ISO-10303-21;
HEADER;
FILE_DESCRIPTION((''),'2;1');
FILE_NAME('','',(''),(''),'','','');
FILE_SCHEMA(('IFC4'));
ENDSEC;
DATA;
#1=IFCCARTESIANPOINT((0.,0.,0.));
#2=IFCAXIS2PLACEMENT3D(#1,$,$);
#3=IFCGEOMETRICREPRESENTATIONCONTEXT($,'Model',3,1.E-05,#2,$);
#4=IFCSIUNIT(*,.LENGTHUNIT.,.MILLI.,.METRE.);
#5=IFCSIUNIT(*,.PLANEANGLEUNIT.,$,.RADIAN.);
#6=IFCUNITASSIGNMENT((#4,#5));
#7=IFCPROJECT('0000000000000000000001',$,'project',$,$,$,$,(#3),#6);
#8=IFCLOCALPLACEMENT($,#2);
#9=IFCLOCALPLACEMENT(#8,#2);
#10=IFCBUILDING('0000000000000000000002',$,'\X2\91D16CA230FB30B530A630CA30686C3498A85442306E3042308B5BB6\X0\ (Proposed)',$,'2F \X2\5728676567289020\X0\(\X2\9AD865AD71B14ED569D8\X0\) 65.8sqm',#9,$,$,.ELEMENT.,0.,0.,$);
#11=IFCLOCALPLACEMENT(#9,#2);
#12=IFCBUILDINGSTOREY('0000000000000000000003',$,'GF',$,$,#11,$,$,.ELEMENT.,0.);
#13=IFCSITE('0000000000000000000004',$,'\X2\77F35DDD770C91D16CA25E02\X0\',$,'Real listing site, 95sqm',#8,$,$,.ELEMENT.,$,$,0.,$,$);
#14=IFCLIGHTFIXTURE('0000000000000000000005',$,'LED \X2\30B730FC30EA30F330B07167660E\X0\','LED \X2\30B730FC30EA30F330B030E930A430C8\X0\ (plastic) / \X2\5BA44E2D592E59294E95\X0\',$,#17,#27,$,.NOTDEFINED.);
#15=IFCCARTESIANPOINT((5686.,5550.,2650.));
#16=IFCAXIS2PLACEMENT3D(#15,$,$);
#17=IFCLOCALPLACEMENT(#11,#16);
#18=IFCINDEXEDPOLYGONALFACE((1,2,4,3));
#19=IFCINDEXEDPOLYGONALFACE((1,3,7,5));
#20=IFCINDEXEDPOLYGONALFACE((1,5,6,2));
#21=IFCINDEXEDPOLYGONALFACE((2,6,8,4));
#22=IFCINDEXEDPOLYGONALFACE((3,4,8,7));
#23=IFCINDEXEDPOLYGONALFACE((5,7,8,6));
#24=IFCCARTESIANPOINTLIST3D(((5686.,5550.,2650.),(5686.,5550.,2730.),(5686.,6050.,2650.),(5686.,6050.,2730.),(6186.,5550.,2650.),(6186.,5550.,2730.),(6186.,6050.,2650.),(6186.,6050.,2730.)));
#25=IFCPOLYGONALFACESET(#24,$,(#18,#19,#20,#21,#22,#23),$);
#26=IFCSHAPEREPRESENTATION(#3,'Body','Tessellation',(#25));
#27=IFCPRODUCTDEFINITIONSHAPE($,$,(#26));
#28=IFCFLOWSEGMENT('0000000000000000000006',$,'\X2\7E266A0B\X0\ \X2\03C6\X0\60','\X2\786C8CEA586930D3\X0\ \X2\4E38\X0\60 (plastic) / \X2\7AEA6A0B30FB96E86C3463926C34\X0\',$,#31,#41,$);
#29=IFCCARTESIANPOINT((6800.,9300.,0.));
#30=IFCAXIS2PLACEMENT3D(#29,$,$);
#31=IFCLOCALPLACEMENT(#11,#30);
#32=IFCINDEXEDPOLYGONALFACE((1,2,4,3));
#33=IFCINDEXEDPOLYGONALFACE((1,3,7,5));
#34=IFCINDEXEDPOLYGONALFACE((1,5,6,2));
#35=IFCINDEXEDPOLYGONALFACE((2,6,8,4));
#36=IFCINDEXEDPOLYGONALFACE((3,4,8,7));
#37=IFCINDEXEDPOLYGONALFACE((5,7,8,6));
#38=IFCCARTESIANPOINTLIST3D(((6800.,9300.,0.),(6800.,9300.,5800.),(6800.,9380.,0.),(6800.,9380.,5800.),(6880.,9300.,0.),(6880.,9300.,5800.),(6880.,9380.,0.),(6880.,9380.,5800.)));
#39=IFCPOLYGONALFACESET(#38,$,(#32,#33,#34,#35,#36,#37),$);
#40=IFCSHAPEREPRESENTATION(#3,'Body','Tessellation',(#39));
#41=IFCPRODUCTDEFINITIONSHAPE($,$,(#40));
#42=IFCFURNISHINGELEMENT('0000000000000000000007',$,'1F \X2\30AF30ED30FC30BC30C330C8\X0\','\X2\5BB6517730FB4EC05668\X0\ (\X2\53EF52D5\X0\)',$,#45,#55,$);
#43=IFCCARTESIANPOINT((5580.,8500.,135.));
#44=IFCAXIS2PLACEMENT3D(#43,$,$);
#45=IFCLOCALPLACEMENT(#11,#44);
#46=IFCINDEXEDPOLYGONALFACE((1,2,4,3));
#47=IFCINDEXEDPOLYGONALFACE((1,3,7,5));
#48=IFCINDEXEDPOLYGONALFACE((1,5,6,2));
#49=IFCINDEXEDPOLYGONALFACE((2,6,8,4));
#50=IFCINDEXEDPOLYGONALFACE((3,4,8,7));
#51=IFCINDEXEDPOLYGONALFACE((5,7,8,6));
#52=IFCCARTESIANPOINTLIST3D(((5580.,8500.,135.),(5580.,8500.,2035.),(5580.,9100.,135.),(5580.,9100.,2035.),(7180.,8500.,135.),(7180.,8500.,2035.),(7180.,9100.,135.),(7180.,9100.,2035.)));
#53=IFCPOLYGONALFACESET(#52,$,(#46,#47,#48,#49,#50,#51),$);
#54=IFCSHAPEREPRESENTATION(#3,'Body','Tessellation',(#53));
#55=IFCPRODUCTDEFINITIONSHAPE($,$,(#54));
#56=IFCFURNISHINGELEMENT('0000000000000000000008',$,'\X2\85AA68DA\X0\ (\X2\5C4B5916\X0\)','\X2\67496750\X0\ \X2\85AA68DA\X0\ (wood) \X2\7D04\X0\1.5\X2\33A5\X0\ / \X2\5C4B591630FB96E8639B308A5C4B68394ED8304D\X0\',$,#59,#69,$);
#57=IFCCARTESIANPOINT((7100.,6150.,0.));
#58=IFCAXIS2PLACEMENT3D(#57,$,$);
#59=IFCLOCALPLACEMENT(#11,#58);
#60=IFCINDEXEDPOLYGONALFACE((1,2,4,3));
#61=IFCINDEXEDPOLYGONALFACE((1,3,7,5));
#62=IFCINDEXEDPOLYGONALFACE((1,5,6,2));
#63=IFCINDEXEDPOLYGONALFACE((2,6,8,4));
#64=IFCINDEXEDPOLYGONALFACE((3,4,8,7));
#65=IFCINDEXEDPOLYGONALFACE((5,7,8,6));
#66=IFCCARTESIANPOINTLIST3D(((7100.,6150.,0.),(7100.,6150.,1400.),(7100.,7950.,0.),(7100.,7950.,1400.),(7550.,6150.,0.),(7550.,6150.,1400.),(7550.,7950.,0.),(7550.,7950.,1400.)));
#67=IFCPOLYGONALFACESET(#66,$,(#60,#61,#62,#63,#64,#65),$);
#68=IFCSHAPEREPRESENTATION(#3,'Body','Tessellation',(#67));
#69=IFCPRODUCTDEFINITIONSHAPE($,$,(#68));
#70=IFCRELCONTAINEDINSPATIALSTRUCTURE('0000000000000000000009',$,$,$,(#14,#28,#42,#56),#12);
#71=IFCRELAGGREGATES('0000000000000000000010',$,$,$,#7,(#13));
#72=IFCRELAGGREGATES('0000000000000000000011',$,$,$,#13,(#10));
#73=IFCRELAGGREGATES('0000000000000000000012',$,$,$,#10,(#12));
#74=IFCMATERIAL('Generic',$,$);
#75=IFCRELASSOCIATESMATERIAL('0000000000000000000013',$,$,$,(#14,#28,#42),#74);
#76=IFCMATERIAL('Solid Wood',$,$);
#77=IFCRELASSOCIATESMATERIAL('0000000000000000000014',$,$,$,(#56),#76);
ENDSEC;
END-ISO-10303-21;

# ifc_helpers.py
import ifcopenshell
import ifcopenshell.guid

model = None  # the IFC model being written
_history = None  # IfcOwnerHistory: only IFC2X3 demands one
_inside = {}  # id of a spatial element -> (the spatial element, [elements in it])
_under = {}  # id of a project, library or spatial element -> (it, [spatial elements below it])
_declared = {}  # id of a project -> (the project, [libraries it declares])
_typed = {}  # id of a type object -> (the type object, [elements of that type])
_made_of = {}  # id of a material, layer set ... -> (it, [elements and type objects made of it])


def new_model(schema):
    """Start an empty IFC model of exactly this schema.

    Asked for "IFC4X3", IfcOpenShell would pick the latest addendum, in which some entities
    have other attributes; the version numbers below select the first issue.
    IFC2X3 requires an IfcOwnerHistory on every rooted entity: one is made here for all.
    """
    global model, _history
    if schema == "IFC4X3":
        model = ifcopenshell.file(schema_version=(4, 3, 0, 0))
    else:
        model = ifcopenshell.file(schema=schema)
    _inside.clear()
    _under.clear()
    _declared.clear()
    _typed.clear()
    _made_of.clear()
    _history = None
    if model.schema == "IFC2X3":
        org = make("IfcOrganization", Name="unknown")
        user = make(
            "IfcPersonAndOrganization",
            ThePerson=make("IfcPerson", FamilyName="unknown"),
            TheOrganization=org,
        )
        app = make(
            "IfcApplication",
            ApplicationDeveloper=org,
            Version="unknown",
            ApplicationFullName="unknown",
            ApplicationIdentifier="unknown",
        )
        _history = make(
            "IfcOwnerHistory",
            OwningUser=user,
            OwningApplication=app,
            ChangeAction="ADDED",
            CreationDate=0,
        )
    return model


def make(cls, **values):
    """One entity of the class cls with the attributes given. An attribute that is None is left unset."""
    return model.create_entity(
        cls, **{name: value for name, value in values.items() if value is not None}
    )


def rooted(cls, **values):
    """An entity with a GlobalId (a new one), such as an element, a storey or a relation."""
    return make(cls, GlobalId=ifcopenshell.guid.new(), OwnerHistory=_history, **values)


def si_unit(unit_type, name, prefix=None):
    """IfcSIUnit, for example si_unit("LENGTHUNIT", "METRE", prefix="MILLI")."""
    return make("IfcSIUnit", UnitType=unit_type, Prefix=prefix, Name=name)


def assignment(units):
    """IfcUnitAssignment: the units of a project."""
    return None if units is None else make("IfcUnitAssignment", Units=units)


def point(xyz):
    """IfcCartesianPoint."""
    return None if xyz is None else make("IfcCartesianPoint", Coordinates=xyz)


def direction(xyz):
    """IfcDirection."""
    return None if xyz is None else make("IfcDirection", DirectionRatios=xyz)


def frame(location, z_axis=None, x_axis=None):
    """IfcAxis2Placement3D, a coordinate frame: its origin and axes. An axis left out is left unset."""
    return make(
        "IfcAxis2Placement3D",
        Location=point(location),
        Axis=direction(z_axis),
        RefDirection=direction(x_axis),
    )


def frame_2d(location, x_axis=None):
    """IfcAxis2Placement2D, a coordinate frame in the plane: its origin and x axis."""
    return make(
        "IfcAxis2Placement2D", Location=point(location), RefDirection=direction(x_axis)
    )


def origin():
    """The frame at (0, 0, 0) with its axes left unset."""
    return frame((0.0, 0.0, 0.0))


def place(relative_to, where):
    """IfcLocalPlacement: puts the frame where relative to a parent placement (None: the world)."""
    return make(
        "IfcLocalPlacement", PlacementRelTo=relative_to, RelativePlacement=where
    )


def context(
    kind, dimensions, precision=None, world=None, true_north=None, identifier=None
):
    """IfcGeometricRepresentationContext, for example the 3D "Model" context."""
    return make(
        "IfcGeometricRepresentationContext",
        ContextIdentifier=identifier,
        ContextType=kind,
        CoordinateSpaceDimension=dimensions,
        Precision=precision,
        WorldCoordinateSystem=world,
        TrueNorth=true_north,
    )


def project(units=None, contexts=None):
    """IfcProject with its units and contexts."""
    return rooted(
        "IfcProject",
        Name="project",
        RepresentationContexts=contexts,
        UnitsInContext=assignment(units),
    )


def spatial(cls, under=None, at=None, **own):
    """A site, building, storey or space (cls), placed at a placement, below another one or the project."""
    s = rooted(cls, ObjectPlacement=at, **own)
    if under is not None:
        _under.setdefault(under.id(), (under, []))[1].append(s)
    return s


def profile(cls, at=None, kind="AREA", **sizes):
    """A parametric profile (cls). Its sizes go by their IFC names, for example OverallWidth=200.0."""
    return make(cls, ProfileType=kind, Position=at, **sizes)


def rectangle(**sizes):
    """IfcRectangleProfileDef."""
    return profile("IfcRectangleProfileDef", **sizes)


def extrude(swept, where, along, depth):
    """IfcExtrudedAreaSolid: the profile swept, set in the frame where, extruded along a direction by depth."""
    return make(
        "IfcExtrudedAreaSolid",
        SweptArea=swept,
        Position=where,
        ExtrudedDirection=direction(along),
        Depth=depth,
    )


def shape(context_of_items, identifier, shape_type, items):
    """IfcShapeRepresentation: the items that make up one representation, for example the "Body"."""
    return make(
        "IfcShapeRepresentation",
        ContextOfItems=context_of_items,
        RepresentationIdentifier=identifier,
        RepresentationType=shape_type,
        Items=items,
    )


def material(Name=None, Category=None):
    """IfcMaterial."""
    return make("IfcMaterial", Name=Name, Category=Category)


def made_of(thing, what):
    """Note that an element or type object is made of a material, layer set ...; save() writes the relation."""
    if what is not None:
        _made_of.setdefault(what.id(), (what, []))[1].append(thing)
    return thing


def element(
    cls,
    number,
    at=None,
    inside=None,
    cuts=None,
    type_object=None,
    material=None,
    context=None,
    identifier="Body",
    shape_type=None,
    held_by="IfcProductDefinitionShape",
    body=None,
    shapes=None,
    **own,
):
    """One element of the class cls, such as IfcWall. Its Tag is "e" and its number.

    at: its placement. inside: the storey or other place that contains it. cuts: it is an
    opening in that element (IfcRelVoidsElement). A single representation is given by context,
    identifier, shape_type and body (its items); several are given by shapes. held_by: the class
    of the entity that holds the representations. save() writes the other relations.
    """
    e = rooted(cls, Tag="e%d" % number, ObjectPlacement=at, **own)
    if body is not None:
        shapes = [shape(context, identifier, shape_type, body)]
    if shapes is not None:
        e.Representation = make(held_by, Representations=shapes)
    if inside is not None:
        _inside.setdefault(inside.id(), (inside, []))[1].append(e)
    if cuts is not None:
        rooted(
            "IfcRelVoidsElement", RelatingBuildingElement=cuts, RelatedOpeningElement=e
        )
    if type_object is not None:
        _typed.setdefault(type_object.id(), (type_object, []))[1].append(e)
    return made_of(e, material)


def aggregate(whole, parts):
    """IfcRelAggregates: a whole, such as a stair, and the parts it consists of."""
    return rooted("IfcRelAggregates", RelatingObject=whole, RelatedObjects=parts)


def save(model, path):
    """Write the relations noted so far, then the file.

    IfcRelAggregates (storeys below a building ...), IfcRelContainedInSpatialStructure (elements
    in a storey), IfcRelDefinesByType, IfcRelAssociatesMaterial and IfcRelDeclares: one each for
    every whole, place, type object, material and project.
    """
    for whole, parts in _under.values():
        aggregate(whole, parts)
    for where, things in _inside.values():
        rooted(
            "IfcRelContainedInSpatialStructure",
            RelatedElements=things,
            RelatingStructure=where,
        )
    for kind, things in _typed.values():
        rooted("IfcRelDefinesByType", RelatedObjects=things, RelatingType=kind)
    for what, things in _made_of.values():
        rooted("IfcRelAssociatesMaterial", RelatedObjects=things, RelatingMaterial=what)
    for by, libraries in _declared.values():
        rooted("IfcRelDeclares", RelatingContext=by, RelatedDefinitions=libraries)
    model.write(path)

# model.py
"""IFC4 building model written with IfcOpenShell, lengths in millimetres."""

from ifc_helpers import new_model, si_unit, frame, frame_2d, origin, place, context, project, spatial, rectangle, extrude, material, element, save


model = new_model("IFC4")

# Units and contexts
model_context = context("Model", 3, precision=1e-05, world=origin())
ifc_project = project(units=[si_unit("LENGTHUNIT", "METRE", prefix="MILLI"), si_unit("PLANEANGLEUNIT", "RADIAN")], contexts=[model_context])

# Site, building, storey
site_placement = place(None, origin())
site = spatial("IfcSite", under=ifc_project, at=site_placement, Name="石川県金沢市", ObjectType="Real listing site, 95sqm", CompositionType="ELEMENT", RefElevation=0.0)
building_placement = place(site_placement, origin())
building = spatial("IfcBuilding", under=site, at=building_placement, Name="金沢・サウナと水風呂のある家 (Proposed)", ObjectType="2F 在来木造(高断熱仕様) 65.8sqm", CompositionType="ELEMENT", ElevationOfRefHeight=0.0, ElevationOfTerrain=0.0)
storey_placement = place(building_placement, origin())
storey = spatial("IfcBuildingStorey", under=building, at=storey_placement, Name="GF", CompositionType="ELEMENT", Elevation=0.0)

# Shared definitions
ifc_material_1 = material(Name="Solid Wood")

# Shared definitions
ifc_material_2 = material(Name="Generic")

# Light fixture
light_fixture_placement = place(storey_placement, frame((5686.0, 5550.0, 2650.0)))
element("IfcLightFixture", 1, at=light_fixture_placement, inside=storey, material=ifc_material_2, Name="LED シーリング照明", Description="LED シーリングライト (plastic) / 室中央天井", PredefinedType="NOTDEFINED", context=model_context, shape_type="SweptSolid", body=[
    extrude(rectangle(XDim=500.0, YDim=500.0, at=frame_2d((250.0, 250.0))), frame((5686.0, 5550.0, 2650.0)), (0.0, 0.0, 1.0), 80.0),
])

# Flow segment
flow_segment_placement = place(storey_placement, frame((6800.0, 9300.0, 0.0)))
element("IfcFlowSegment", 2, at=flow_segment_placement, inside=storey, material=ifc_material_2, Name="縦樋 φ60", Description="硬質塩ビ 丸60 (plastic) / 竪樋・雨水排水", context=model_context, shape_type="SweptSolid", body=[
    extrude(rectangle(XDim=80.0, YDim=80.0, at=frame_2d((40.0, 40.0))), frame((6800.0, 9300.0, 0.0)), (0.0, 0.0, 1.0), 5800.0),
])

# Furnishing elements
furnishing_1_placement = place(storey_placement, frame((5580.0, 8500.0, 135.0)))
element("IfcFurnishingElement", 3, at=furnishing_1_placement, inside=storey, material=ifc_material_2, Name="1F クローゼット", Description="家具・什器 (可動)", context=model_context, shape_type="SweptSolid", body=[
    extrude(rectangle(XDim=1600.0, YDim=600.0, at=frame_2d((800.0, 300.0))), frame((5580.0, 8500.0, 135.0)), (0.0, 0.0, 1.0), 1900.0),
])
furnishing_2_placement = place(storey_placement, frame((7100.0, 6150.0, 0.0)))
element("IfcFurnishingElement", 4, at=furnishing_2_placement, inside=storey, material=ifc_material_1, Name="薪棚 (屋外)", Description="杉材 薪棚 (wood) 約1.5㎥ / 屋外・雨掛り屋根付き", context=model_context, shape_type="SweptSolid", body=[
    extrude(rectangle(XDim=450.0, YDim=1800.0, at=frame_2d((225.0, 900.0))), frame((7100.0, 6150.0, 0.0)), (0.0, 0.0, 1.0), 1400.0),
])

save(model, "model.ifc")
